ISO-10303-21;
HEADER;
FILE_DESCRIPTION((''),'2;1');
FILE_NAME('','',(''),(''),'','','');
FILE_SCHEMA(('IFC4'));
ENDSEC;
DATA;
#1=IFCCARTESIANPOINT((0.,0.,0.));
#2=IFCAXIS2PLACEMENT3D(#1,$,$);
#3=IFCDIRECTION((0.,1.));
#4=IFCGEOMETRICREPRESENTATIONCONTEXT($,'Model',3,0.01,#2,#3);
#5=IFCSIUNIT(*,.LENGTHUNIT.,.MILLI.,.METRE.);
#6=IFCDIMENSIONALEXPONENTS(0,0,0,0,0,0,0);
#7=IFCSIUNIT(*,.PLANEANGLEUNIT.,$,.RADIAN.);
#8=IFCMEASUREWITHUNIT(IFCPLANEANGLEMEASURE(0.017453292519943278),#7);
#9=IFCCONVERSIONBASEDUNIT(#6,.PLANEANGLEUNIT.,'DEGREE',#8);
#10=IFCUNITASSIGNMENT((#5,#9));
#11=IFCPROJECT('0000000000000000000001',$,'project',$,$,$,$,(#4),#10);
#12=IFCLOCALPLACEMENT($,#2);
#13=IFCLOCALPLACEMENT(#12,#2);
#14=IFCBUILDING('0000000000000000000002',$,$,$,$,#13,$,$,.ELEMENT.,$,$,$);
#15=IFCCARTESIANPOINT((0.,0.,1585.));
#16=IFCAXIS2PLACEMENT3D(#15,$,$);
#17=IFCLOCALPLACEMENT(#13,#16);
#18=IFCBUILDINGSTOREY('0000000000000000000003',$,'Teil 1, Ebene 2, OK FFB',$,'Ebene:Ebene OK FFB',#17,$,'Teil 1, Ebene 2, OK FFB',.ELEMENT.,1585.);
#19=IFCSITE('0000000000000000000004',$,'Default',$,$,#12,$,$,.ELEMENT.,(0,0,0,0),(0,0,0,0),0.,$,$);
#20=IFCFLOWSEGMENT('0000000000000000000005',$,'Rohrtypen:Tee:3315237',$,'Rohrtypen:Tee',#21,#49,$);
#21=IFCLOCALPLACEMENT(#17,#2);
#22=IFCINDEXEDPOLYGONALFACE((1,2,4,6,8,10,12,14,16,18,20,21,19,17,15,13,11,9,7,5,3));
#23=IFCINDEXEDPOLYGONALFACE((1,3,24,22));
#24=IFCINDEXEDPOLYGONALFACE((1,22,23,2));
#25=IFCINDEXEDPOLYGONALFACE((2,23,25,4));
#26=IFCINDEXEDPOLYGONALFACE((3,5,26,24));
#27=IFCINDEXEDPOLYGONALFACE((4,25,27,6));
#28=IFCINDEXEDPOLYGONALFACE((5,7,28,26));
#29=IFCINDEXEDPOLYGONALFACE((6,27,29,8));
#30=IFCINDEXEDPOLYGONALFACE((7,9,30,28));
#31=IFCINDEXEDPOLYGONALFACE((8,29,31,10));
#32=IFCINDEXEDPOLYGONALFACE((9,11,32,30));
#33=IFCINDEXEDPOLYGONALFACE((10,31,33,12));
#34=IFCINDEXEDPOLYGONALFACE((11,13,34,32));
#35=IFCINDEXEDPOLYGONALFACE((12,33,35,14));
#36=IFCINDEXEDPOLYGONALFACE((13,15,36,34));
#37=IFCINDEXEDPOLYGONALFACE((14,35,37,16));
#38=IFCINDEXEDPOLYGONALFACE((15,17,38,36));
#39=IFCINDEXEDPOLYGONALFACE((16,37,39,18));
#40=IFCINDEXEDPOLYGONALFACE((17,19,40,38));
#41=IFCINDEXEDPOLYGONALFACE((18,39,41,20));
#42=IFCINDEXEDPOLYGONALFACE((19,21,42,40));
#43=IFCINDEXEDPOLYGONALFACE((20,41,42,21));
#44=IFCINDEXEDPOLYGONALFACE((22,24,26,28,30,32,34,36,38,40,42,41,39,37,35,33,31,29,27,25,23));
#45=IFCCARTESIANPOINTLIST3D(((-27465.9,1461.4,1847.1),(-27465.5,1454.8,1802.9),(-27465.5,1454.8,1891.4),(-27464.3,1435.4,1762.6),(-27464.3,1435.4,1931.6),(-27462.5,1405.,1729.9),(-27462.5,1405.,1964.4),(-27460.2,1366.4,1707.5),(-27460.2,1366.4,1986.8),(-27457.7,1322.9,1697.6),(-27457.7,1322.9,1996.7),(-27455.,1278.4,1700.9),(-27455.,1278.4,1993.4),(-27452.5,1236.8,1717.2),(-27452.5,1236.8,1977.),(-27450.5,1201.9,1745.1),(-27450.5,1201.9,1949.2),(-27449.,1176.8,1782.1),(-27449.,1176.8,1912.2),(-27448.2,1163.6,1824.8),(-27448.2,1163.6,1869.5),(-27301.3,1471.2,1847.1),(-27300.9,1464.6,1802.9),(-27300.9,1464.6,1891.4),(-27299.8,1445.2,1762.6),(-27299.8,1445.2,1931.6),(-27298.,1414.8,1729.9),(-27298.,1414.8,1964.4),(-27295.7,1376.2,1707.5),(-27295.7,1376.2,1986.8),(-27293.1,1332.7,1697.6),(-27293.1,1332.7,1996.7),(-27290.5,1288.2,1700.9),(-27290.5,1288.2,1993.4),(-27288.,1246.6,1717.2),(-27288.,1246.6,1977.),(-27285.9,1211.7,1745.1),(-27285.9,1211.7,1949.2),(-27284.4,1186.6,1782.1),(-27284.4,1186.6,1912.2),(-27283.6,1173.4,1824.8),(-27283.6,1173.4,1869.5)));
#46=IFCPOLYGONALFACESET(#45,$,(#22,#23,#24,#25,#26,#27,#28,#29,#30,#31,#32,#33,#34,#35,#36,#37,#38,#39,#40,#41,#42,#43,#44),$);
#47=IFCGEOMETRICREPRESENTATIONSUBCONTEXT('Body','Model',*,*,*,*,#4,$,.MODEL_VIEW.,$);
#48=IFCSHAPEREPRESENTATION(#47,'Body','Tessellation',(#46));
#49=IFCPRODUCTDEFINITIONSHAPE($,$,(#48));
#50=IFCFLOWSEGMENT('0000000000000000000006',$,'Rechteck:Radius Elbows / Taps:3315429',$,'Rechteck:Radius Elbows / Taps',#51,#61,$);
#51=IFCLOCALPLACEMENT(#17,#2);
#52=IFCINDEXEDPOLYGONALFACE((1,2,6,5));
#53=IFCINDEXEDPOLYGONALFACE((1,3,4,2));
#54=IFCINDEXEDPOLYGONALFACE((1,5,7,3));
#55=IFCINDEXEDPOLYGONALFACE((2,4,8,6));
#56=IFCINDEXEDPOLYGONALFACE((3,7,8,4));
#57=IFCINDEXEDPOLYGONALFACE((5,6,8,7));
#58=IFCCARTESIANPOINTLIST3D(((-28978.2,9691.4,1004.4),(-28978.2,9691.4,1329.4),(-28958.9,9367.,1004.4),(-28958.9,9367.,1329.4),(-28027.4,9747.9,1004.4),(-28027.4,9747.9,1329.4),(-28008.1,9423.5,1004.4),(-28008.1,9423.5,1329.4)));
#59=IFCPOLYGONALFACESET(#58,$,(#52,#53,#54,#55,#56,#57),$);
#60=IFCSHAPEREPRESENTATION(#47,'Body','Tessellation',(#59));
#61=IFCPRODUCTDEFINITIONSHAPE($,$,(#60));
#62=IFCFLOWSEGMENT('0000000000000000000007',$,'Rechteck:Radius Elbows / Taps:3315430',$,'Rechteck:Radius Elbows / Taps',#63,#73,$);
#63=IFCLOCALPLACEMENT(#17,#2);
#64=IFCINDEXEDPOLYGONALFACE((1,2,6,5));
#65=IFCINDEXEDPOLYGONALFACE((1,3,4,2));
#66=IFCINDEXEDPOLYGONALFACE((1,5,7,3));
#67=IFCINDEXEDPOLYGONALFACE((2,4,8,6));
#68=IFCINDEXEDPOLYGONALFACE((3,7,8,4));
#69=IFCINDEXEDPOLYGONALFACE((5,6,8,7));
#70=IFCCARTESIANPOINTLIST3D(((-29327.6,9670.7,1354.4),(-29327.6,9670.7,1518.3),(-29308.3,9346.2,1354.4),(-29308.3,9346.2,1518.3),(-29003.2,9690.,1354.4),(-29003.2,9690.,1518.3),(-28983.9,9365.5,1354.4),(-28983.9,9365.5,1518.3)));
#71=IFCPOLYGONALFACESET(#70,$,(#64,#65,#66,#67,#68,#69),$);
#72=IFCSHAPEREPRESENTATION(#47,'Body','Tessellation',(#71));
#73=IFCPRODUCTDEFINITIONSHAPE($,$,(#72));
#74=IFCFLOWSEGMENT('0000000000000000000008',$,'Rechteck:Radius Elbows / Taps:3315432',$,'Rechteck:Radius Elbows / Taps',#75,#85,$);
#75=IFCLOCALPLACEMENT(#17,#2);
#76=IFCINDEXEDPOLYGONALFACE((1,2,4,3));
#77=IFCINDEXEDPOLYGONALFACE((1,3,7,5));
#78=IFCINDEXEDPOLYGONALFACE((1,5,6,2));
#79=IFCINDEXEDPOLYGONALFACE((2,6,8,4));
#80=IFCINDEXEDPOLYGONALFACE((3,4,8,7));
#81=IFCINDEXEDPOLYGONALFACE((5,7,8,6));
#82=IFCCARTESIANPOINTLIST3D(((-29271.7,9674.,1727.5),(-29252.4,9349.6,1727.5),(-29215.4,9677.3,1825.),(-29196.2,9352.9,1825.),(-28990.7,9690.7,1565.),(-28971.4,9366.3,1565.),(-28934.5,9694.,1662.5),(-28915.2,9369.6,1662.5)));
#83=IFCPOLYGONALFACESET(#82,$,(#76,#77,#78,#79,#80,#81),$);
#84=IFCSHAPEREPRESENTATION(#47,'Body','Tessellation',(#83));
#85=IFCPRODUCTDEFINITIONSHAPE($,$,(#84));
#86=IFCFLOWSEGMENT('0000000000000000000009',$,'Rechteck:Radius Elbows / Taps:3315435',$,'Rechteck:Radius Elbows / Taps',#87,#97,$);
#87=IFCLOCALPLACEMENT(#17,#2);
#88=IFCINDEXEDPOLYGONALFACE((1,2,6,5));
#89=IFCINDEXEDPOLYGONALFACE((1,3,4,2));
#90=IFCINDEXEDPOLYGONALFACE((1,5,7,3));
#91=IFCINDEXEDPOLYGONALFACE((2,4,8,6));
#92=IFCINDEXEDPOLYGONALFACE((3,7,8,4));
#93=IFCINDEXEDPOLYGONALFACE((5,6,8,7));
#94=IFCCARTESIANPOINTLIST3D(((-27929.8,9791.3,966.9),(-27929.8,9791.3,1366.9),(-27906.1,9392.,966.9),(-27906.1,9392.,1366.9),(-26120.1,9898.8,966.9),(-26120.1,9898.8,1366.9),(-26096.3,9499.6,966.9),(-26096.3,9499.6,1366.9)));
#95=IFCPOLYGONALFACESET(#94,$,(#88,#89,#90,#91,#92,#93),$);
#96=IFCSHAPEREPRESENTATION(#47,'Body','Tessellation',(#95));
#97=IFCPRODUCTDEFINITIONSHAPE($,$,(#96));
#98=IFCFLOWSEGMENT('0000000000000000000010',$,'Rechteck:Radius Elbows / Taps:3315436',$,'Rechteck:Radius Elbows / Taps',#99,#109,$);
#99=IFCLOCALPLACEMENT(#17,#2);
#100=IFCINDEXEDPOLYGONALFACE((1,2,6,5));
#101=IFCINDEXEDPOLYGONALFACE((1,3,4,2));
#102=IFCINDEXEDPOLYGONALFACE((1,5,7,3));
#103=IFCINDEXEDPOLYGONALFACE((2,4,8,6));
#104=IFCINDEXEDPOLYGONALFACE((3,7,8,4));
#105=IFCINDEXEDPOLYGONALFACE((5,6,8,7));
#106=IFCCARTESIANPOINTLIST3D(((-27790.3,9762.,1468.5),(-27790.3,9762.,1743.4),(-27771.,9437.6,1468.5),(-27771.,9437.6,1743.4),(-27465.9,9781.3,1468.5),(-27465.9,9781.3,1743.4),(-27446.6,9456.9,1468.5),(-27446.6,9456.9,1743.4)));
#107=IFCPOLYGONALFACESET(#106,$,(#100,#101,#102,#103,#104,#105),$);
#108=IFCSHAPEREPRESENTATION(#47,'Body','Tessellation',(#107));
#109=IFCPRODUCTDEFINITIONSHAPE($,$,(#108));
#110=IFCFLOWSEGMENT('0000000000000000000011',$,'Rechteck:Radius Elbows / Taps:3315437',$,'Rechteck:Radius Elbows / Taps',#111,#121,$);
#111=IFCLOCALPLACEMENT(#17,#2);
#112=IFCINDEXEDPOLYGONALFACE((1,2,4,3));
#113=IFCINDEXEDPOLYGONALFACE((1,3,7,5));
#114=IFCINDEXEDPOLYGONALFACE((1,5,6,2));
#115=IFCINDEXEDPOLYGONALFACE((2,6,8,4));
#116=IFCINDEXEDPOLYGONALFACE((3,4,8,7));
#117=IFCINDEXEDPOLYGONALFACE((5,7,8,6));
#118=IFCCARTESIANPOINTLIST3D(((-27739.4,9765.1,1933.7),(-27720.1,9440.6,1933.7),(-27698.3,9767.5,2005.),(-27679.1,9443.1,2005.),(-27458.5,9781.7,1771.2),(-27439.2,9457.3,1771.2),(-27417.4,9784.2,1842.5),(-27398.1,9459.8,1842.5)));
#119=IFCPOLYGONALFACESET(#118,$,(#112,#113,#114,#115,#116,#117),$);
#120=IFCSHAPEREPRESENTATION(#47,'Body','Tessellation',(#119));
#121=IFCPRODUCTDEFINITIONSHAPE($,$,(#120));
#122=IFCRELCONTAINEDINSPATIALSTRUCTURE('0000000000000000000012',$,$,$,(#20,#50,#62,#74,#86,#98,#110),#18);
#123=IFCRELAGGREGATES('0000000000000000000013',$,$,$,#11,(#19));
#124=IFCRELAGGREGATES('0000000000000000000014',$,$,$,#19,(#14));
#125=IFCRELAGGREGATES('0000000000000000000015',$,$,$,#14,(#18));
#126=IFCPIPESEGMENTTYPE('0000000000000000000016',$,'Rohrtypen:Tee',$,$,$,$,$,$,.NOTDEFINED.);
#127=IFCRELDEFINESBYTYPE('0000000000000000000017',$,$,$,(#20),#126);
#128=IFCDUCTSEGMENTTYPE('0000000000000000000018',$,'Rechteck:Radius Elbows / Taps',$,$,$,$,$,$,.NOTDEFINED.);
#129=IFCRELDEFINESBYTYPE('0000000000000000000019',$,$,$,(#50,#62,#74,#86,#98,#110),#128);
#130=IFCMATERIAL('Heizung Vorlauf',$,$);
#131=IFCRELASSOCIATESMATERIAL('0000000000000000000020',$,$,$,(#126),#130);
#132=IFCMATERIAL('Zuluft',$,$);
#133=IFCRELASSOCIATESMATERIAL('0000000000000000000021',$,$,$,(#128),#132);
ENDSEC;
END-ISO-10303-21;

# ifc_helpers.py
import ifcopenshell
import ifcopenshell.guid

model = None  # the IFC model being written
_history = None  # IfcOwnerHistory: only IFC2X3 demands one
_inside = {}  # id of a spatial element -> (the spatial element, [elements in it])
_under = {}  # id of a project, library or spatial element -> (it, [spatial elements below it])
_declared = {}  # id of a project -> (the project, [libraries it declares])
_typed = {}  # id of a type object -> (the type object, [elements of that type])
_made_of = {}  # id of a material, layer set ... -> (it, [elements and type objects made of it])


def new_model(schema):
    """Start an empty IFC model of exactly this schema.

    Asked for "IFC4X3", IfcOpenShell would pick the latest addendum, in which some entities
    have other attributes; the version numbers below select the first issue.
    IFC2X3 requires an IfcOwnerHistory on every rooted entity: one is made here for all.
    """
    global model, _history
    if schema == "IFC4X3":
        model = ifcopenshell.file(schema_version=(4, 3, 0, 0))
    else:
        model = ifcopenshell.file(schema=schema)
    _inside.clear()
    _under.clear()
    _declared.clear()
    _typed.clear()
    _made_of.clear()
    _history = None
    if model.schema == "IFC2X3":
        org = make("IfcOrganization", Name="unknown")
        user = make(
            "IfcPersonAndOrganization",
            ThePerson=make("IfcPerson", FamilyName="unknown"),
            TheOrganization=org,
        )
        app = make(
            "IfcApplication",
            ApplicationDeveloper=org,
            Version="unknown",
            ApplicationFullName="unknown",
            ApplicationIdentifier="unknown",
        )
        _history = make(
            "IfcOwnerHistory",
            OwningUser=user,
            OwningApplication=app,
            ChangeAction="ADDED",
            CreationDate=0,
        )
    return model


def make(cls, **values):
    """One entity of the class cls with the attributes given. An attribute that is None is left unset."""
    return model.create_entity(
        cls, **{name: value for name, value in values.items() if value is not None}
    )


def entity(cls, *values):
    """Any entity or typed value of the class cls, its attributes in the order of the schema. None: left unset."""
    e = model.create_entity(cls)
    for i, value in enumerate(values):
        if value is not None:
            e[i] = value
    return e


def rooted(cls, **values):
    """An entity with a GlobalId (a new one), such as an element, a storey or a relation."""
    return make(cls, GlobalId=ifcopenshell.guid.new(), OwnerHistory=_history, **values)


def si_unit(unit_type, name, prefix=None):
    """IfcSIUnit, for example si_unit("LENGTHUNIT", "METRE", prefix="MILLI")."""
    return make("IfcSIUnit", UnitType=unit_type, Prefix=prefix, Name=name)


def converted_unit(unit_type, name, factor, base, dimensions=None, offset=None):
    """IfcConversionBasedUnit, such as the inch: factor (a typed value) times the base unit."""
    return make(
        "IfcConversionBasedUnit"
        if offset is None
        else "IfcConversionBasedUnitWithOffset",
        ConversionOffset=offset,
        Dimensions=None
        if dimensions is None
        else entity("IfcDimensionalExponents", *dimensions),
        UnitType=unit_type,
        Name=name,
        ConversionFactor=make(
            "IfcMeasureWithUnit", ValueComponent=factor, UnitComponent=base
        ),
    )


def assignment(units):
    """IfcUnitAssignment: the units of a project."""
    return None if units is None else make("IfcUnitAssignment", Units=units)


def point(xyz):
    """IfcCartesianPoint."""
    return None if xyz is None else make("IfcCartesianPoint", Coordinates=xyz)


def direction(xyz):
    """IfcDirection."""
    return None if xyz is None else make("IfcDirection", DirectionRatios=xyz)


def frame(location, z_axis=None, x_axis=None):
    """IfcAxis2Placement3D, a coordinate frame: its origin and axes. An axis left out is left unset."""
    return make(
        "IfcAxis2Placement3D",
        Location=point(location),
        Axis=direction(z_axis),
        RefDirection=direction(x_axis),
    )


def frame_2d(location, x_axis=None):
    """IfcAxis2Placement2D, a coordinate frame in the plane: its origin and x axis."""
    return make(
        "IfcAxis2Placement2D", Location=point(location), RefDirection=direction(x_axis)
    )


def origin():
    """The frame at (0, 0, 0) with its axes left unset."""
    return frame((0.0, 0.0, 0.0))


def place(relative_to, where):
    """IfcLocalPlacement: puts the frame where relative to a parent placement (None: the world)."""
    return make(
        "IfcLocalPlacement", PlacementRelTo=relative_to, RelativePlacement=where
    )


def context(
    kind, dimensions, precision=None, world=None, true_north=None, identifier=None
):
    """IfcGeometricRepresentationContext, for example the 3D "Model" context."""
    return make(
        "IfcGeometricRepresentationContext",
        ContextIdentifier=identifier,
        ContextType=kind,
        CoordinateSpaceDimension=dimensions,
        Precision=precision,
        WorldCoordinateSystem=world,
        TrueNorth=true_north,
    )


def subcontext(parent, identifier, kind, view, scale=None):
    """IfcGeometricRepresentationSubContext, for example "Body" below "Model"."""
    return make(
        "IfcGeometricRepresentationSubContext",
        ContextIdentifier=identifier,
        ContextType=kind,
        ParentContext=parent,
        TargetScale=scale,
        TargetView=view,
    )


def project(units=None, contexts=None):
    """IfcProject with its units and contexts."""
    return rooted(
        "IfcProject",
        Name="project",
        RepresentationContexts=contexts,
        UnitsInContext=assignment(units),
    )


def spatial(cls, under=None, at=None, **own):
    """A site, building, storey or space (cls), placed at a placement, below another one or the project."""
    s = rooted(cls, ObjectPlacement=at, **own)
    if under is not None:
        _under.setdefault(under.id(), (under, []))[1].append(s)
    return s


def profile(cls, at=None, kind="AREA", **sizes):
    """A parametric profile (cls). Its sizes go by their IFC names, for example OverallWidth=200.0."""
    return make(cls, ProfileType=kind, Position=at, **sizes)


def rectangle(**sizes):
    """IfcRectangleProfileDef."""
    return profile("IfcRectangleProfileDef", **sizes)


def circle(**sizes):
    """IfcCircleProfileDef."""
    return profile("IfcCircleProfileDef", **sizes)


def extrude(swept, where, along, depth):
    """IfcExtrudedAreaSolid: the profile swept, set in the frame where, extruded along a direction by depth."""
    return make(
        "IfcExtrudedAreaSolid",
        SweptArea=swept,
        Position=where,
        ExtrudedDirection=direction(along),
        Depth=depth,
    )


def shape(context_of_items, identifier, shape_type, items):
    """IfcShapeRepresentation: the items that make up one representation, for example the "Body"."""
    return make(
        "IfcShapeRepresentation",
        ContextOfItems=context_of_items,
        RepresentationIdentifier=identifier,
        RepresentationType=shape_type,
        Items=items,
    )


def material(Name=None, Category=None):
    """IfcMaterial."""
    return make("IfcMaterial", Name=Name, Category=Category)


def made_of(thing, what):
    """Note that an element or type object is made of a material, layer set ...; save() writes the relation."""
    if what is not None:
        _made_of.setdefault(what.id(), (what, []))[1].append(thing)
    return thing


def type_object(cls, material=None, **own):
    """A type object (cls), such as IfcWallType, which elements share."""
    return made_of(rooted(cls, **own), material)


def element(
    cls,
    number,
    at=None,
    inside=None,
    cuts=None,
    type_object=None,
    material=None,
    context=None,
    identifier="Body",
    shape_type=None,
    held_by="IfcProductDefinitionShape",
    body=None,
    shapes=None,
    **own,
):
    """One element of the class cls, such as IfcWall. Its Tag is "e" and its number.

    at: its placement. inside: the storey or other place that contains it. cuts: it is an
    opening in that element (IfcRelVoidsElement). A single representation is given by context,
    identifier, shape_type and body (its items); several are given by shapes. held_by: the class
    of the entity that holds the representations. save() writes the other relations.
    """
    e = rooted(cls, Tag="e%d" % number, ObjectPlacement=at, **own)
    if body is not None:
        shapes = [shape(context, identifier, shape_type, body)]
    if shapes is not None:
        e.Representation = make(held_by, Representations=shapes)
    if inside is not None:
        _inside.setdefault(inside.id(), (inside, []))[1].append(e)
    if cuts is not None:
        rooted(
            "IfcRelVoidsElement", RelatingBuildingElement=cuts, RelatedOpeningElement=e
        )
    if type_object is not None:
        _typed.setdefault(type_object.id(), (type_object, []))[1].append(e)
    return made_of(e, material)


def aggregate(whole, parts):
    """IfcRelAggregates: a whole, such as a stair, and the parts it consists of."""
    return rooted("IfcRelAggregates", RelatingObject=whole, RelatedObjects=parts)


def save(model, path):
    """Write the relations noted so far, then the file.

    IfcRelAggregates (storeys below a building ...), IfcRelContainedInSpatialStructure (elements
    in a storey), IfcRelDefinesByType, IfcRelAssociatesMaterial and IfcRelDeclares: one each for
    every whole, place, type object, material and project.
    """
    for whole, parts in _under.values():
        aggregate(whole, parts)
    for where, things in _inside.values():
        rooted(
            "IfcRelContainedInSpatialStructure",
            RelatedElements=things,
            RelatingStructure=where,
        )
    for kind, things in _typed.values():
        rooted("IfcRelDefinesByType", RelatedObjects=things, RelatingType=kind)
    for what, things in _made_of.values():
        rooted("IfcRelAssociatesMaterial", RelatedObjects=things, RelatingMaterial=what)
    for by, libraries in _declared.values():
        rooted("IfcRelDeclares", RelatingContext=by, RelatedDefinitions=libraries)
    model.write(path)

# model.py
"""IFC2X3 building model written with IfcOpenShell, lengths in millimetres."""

from ifc_helpers import new_model, entity, si_unit, converted_unit, direction, frame, frame_2d, origin, place, context, subcontext, project, spatial, rectangle, circle, extrude, material, type_object, element, save


model = new_model("IFC2X3")

# Units and contexts
model_context = context("Model", 3, precision=0.01, world=origin(), true_north=direction((0.0, 1.0)))
body_context = subcontext(model_context, "Body", "Model", "MODEL_VIEW")
ifc_project = project(units=[si_unit("LENGTHUNIT", "METRE", prefix="MILLI"), converted_unit("PLANEANGLEUNIT", "DEGREE", entity("IfcPlaneAngleMeasure", 0.017453292519943278), si_unit("PLANEANGLEUNIT", "RADIAN"), dimensions=[0, 0, 0, 0, 0, 0, 0])], contexts=[model_context])

# Site, building, storey
site_placement = place(None, origin())
site = spatial("IfcSite", under=ifc_project, at=site_placement, Name="Default", CompositionType="ELEMENT", RefLatitude=(0, 0, 0, 0), RefLongitude=(0, 0, 0, 0), RefElevation=0.0)
building_placement = place(site_placement, origin())
building = spatial("IfcBuilding", under=site, at=building_placement, CompositionType="ELEMENT")
storey_placement = place(building_placement, frame((0.0, 0.0, 1585.0)))
storey = spatial("IfcBuildingStorey", under=building, at=storey_placement, Name="Teil 1, Ebene 2, OK FFB", ObjectType="Ebene:Ebene OK FFB", LongName="Teil 1, Ebene 2, OK FFB", CompositionType="ELEMENT", Elevation=1585.0)

# Flow segments
ifc_material_1 = material(Name="Heizung Vorlauf")
pipe_segment_type = type_object("IfcPipeSegmentType", Name="Rohrtypen:Tee", PredefinedType="NOTDEFINED", material=ifc_material_1)
flow_segment_1_placement = place(storey_placement, origin())
element("IfcFlowSegment", 1, at=flow_segment_1_placement, inside=storey, type_object=pipe_segment_type, Name="Rohrtypen:Tee:3315237", ObjectType="Rohrtypen:Tee", context=body_context, shape_type="SweptSolid", body=[
    extrude(circle(Radius=150.0, at=frame_2d((0.0, 0.0), x_axis=(1.0, 0.0))), frame((-27457.0, 1311.7, 1847.1), z_axis=(0.998239, 0.059319, 0.0), x_axis=(-0.059319, 0.998239, 0.0)), (0.0, 0.0, 1.0), 164.8),
])
ifc_material_2 = material(Name="Zuluft")
duct_segment_type = type_object("IfcDuctSegmentType", Name="Rechteck:Radius Elbows / Taps", PredefinedType="NOTDEFINED", material=ifc_material_2)
flow_segment_2_placement = place(storey_placement, origin())
element("IfcFlowSegment", 2, at=flow_segment_2_placement, inside=storey, type_object=duct_segment_type, Name="Rechteck:Radius Elbows / Taps:3315429", ObjectType="Rechteck:Radius Elbows / Taps", context=body_context, shape_type="SweptSolid", body=[
    extrude(rectangle(XDim=952.5, YDim=325.0, at=frame_2d((0.0, 0.0), x_axis=(1.0, 0.0))), frame((-28493.2, 9557.5, 1004.4), z_axis=(0.0, 0.0, 1.0), x_axis=(0.998239, 0.059319, 0.0)), (0.0, 0.0, 1.0), 325.0),
])
flow_segment_3_placement = place(storey_placement, origin())
element("IfcFlowSegment", 3, at=flow_segment_3_placement, inside=storey, type_object=duct_segment_type, Name="Rechteck:Radius Elbows / Taps:3315430", ObjectType="Rechteck:Radius Elbows / Taps", context=body_context, shape_type="SweptSolid", body=[
    extrude(rectangle(XDim=325.0, YDim=325.0, at=frame_2d((0.0, 0.0), x_axis=(1.0, 0.0))), frame((-29155.8, 9518.1, 1354.4), z_axis=(0.0, 0.0, 1.0), x_axis=(-0.059319, 0.998239, 0.0)), (0.0, 0.0, 1.0), 164.0),
])
flow_segment_4_placement = place(storey_placement, origin())
element("IfcFlowSegment", 4, at=flow_segment_4_placement, inside=storey, type_object=duct_segment_type, Name="Rechteck:Radius Elbows / Taps:3315432", ObjectType="Rechteck:Radius Elbows / Taps", context=body_context, shape_type="SweptSolid", body=[
    extrude(rectangle(XDim=112.6, YDim=325.0, at=frame_2d((0.0, 0.0), x_axis=(1.0, 0.0))), frame((-29233.9, 9513.5, 1776.2), z_axis=(0.8645, 0.051372, -0.5), x_axis=(0.49912, 0.02966, 0.866025)), (0.0, 0.0, 1.0), 325.0),
])
flow_segment_5_placement = place(storey_placement, origin())
element("IfcFlowSegment", 5, at=flow_segment_5_placement, inside=storey, type_object=duct_segment_type, Name="Rechteck:Radius Elbows / Taps:3315435", ObjectType="Rechteck:Radius Elbows / Taps", context=body_context, shape_type="SweptSolid", body=[
    extrude(rectangle(XDim=1812.9, YDim=400.0, at=frame_2d((0.0, 0.0), x_axis=(1.0, 0.0))), frame((-27013.1, 9645.4, 966.9), z_axis=(0.0, 0.0, 1.0), x_axis=(0.998239, 0.059319, 0.0)), (0.0, 0.0, 1.0), 400.0),
])
flow_segment_6_placement = place(storey_placement, origin())
element("IfcFlowSegment", 6, at=flow_segment_6_placement, inside=storey, type_object=duct_segment_type, Name="Rechteck:Radius Elbows / Taps:3315436", ObjectType="Rechteck:Radius Elbows / Taps", context=body_context, shape_type="SweptSolid", body=[
    extrude(rectangle(XDim=325.0, YDim=325.0, at=frame_2d((0.0, 0.0), x_axis=(1.0, 0.0))), frame((-27618.5, 9609.5, 1468.5), z_axis=(0.0, 0.0, 1.0), x_axis=(-0.059319, 0.998239, 0.0)), (0.0, 0.0, 1.0), 275.0),
])
flow_segment_7_placement = place(storey_placement, origin())
element("IfcFlowSegment", 7, at=flow_segment_7_placement, inside=storey, type_object=duct_segment_type, Name="Rechteck:Radius Elbows / Taps:3315437", ObjectType="Rechteck:Radius Elbows / Taps", context=body_context, shape_type="SweptSolid", body=[
    extrude(rectangle(XDim=82.3, YDim=325.0, at=frame_2d((0.0, 0.0), x_axis=(1.0, 0.0))), frame((-27559.1, 9450.2, 1888.1), z_axis=(-0.059319, 0.998239, 0.0), x_axis=(0.49912, 0.02966, 0.866025)), (0.0, 0.0, 1.0), 325.0),
])

save(model, "model.ifc")
